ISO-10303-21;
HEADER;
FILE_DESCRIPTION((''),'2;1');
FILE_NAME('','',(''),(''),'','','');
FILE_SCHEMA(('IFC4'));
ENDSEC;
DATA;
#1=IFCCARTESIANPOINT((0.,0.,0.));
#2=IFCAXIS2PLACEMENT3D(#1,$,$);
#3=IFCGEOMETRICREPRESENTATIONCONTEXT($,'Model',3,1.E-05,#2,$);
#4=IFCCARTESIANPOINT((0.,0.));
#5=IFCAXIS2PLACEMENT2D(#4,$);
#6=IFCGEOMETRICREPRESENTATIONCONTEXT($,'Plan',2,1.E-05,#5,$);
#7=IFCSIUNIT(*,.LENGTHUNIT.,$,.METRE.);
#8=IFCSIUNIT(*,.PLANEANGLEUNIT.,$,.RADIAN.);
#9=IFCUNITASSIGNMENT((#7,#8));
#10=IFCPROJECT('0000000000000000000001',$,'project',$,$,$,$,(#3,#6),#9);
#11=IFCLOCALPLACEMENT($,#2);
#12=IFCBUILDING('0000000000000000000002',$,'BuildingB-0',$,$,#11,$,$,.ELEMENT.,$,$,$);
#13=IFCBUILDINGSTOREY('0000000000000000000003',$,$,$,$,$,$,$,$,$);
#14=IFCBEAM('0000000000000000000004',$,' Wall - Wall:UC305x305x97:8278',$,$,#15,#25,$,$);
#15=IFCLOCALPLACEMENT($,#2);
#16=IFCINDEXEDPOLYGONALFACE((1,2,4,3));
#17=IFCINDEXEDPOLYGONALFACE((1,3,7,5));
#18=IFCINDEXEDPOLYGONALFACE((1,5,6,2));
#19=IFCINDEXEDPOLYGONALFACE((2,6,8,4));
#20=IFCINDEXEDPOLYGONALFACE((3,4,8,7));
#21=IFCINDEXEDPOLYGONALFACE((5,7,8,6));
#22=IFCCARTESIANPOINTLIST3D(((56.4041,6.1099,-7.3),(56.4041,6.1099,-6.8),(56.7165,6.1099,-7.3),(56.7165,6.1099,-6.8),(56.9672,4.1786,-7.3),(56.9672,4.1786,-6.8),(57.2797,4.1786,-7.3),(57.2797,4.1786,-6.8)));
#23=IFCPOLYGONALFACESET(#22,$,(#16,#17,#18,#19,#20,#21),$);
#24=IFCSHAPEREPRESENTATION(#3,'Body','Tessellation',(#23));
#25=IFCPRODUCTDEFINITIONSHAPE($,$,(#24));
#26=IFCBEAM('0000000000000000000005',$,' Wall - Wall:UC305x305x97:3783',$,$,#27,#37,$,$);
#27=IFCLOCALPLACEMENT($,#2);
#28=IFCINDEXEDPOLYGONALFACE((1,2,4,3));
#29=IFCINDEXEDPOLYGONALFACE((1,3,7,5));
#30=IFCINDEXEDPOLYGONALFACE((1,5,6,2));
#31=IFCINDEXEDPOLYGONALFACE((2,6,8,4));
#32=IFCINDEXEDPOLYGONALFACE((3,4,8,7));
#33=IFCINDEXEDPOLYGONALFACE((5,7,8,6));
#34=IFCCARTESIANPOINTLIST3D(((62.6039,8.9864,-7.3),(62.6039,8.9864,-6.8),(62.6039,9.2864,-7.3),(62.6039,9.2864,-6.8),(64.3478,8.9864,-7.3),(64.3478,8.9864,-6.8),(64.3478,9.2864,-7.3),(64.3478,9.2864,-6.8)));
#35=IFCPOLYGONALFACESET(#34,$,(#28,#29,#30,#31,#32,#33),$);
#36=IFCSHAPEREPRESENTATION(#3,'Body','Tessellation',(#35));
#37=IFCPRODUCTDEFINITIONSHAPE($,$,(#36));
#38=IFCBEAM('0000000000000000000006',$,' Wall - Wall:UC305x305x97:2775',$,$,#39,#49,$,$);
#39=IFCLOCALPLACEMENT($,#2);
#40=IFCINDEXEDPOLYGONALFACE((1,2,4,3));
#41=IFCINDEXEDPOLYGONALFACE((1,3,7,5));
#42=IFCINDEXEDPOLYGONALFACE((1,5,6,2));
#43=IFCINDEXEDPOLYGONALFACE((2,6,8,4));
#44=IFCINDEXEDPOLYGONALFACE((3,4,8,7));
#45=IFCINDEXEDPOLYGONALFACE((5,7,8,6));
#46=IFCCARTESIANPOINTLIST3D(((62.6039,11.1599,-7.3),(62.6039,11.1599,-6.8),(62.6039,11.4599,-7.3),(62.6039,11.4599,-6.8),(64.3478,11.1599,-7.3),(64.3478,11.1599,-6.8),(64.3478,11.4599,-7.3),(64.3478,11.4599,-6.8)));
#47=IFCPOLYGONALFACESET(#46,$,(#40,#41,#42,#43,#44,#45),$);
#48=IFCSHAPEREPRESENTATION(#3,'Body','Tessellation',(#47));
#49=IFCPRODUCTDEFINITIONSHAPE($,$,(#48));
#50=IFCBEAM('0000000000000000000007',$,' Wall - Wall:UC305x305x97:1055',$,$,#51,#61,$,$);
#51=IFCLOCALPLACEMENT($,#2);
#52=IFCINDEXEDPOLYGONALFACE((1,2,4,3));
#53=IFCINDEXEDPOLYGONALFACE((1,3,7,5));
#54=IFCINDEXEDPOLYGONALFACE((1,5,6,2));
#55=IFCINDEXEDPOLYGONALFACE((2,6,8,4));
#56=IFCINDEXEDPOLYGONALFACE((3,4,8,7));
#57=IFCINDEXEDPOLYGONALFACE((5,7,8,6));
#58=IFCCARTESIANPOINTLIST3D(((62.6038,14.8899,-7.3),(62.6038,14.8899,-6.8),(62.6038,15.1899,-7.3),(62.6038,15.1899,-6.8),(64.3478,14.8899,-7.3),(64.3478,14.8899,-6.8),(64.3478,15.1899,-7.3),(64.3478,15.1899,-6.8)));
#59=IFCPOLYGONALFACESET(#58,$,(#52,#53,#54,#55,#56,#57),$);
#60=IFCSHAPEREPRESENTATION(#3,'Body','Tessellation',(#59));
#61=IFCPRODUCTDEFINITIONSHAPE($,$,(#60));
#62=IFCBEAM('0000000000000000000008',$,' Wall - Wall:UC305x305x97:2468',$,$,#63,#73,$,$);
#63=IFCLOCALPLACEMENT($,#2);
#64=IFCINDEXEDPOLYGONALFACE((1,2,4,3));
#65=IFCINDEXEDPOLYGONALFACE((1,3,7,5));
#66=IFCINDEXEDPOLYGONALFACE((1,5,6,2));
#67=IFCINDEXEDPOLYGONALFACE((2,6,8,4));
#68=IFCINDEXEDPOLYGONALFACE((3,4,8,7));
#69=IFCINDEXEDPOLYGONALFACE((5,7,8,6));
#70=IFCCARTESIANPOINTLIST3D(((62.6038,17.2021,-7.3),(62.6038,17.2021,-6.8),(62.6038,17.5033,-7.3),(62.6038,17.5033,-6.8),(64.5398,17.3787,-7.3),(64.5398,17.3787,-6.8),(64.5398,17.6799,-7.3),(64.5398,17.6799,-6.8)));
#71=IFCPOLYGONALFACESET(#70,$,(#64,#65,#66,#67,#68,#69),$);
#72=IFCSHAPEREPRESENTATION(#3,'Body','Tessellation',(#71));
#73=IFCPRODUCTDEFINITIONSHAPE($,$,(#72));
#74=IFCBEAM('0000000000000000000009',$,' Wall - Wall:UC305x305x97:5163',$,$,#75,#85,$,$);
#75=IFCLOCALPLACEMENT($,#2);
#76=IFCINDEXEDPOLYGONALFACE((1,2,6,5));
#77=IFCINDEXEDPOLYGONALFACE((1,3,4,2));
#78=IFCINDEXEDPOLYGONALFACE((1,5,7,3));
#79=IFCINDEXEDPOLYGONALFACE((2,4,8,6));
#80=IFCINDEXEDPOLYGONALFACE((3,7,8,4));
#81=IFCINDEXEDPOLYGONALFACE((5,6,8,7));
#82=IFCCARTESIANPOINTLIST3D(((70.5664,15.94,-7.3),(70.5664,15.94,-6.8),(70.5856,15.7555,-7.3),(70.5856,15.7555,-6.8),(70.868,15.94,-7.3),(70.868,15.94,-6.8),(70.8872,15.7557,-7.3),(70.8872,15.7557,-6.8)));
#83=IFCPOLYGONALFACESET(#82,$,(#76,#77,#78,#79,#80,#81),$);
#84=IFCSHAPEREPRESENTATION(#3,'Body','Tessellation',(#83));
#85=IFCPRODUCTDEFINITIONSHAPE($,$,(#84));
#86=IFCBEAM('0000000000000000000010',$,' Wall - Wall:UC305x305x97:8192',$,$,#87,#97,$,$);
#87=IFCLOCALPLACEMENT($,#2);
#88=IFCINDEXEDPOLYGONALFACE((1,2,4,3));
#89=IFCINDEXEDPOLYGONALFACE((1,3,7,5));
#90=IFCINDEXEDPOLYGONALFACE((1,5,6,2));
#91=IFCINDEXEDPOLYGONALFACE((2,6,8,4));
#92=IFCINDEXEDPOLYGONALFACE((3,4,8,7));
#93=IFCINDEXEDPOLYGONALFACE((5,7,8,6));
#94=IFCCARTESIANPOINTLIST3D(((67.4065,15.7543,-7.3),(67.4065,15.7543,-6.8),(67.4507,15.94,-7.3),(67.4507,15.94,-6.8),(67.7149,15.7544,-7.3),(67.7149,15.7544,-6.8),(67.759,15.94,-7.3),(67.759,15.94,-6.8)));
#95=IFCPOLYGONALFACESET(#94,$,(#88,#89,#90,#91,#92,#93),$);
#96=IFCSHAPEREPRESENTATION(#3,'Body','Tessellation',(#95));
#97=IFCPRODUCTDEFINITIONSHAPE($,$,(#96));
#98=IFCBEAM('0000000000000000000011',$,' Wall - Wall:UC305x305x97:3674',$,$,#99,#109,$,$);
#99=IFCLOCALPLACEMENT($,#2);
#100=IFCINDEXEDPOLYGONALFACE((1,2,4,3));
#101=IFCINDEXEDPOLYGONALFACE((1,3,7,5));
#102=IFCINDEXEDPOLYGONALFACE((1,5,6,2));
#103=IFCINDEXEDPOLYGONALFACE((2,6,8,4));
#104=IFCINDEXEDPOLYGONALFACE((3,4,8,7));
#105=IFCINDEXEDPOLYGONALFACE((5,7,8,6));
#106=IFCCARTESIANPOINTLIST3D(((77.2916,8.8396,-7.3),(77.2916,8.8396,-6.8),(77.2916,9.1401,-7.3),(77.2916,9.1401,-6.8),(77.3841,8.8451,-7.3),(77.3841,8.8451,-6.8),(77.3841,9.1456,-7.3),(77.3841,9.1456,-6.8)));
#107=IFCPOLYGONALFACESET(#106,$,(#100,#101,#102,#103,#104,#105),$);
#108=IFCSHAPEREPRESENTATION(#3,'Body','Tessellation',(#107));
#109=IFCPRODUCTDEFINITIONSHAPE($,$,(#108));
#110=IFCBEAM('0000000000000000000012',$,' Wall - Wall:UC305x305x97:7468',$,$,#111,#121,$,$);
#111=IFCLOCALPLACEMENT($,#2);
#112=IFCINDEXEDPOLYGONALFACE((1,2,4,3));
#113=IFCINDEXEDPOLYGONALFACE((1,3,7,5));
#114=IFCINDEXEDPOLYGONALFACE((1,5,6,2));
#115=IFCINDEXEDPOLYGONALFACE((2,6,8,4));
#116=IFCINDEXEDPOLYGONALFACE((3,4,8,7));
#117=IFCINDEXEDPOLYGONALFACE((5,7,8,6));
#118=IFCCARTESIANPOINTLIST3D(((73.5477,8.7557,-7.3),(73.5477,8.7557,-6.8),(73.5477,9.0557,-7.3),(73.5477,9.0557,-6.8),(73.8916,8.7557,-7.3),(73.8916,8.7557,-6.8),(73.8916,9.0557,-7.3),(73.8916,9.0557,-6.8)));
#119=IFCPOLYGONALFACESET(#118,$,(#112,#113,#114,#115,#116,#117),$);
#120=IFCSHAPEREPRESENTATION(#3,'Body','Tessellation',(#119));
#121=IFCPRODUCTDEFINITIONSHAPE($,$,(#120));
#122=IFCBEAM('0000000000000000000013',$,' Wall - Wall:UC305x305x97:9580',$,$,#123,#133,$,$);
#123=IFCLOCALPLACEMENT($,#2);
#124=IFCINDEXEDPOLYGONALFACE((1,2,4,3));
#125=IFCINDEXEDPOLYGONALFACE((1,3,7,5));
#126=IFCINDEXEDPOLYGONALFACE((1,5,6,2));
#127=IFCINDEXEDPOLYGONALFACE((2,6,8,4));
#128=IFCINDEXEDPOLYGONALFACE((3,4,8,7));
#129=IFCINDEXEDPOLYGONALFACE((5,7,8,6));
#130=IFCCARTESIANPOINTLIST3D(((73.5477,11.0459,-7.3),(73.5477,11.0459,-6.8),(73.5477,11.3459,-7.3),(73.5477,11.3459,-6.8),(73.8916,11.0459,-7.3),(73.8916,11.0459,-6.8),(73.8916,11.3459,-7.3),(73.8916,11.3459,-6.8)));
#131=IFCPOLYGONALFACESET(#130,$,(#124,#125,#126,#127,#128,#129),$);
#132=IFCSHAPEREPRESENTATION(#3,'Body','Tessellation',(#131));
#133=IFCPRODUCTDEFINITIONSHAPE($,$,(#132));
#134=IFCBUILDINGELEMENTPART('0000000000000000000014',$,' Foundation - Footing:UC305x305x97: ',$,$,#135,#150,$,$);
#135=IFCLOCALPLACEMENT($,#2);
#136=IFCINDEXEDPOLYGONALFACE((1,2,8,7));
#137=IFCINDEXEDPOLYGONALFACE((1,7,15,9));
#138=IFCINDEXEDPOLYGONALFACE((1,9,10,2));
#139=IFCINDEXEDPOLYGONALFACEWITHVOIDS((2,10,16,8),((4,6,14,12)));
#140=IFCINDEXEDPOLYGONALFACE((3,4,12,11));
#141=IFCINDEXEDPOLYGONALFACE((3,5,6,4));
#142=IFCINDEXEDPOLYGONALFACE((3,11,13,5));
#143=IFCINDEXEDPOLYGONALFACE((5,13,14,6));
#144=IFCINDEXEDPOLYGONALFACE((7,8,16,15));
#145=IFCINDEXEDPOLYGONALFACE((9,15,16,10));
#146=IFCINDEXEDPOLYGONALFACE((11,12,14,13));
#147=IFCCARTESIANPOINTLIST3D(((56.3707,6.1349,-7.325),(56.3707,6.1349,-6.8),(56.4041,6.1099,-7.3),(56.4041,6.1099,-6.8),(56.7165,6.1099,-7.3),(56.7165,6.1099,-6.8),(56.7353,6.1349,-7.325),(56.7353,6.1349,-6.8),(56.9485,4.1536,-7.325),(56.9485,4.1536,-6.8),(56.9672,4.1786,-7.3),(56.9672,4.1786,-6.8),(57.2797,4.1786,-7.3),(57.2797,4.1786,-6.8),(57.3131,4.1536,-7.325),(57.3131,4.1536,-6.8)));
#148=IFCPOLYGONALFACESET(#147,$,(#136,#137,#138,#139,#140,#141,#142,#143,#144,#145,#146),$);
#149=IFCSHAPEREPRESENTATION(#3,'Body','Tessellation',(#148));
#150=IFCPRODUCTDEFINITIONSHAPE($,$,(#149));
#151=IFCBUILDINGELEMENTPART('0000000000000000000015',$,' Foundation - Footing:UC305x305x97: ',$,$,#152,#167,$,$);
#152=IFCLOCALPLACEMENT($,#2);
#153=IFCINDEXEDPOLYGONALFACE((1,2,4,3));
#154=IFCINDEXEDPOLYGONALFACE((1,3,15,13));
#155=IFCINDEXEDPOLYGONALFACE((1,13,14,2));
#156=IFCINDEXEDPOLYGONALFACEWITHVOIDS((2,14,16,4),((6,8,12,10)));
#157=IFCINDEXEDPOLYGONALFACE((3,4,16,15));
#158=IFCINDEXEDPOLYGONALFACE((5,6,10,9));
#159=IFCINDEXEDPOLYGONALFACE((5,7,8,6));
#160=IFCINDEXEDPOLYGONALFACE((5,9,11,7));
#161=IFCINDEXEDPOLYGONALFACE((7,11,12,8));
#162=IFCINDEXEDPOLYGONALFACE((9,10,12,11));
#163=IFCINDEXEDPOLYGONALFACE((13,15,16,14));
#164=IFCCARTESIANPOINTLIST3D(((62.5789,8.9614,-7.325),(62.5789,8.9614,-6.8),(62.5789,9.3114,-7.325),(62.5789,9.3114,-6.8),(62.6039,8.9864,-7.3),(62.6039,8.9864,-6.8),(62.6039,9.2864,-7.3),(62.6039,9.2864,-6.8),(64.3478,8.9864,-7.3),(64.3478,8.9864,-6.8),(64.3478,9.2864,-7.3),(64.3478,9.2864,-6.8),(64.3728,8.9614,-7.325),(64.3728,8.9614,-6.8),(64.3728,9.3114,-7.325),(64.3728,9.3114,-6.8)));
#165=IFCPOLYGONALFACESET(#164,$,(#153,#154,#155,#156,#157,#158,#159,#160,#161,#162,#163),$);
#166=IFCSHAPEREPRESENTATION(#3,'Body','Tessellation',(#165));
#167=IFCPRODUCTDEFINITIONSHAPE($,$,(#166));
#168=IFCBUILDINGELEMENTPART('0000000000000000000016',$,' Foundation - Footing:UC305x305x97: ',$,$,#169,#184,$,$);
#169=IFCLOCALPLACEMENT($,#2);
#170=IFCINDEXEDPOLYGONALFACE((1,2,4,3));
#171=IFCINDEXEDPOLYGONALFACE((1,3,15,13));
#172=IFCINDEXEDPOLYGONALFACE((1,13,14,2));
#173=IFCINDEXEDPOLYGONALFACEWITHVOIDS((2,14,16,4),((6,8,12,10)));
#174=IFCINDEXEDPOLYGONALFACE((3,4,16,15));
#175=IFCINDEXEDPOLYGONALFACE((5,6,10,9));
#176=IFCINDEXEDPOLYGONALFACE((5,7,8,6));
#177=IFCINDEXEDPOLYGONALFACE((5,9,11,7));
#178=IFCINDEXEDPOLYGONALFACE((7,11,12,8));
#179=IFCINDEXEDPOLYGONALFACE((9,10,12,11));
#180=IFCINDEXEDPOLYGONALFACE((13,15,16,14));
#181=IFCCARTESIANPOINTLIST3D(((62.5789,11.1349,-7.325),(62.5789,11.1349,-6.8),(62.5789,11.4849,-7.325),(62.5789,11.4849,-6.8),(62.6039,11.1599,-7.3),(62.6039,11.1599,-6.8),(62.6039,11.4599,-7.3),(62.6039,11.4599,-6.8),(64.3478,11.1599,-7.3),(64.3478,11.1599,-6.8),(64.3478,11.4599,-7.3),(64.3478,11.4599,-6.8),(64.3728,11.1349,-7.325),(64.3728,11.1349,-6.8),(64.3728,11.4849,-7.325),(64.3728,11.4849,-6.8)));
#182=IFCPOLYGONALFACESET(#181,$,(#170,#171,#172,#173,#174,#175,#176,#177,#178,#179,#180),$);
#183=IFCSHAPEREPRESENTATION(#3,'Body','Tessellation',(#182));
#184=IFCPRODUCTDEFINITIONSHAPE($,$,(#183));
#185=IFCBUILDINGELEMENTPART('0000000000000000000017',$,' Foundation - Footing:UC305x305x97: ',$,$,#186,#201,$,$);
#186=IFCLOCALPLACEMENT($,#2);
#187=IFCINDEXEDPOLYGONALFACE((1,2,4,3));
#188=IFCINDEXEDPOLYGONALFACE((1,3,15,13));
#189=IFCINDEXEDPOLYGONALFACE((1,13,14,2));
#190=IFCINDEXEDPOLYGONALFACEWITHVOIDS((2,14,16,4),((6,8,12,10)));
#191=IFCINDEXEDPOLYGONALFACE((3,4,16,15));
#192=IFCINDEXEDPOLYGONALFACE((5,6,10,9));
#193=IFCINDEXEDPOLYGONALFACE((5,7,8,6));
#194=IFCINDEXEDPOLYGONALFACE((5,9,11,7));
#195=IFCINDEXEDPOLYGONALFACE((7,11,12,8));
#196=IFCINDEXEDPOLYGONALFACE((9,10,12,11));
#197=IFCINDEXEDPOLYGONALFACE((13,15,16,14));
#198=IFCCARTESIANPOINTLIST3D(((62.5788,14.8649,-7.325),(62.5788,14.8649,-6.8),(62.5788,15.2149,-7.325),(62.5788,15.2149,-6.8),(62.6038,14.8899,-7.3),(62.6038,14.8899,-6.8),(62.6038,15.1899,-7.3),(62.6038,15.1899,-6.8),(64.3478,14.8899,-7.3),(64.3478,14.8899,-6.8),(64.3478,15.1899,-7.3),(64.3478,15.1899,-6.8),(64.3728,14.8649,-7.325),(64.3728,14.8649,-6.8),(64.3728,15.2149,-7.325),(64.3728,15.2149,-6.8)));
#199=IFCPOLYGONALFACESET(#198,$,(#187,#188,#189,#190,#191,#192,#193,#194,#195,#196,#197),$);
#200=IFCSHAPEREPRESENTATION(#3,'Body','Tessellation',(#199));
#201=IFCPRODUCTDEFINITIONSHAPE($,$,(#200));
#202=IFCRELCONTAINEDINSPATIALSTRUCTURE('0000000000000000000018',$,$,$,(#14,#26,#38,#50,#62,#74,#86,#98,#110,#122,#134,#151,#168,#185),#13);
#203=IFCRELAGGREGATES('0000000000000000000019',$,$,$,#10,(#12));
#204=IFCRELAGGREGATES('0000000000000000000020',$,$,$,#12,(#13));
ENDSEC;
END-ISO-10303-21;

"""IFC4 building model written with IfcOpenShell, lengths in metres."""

from ifc_helpers import new_model, si_unit, origin, origin_2d, place, context, project, spatial, polyline, outline, extrude, element, save


model = new_model("IFC4")

# Units and contexts
model_context = context("Model", 3, precision=1e-05, world=origin())
plan_context = context("Plan", 2, precision=1e-05, world=origin_2d())
ifc_project = project(units=[si_unit("LENGTHUNIT", "METRE"), si_unit("PLANEANGLEUNIT", "RADIAN")], contexts=[model_context, plan_context])

# Building, storey
building_placement = place(None, origin())
building = spatial("IfcBuilding", under=ifc_project, at=building_placement, Name="BuildingB-0", CompositionType="ELEMENT")
storey = spatial("IfcBuildingStorey", under=building)

# Beams
element("IfcBeam", 1, inside=storey, Name=" Wall - Wall:UC305x305x97:8278", context=model_context, shape_type="SweptSolid", body=[
    extrude(outline(polyline([(56.9672, 4.1786, -7.3), (57.2797, 4.1786, -7.3), (56.7165, 6.1099, -7.3), (56.4041, 6.1099, -7.3), (56.9672, 4.1786, -7.3)])), None, (0.0, 0.0, 1.0), 0.5),
])
element("IfcBeam", 2, inside=storey, Name=" Wall - Wall:UC305x305x97:3783", context=model_context, shape_type="SweptSolid", body=[
    extrude(outline(polyline([(64.3478, 8.9864, -7.3), (62.6039, 8.9864, -7.3), (62.6039, 9.2864, -7.3), (64.3478, 9.2864, -7.3), (64.3478, 8.9864, -7.3)])), None, (0.0, 0.0, 1.0), 0.5),
])
element("IfcBeam", 3, inside=storey, Name=" Wall - Wall:UC305x305x97:2775", context=model_context, shape_type="SweptSolid", body=[
    extrude(outline(polyline([(64.3478, 11.1599, -7.3), (64.3478, 11.4599, -7.3), (62.6039, 11.4599, -7.3), (62.6039, 11.1599, -7.3), (64.3478, 11.1599, -7.3)])), None, (0.0, 0.0, 1.0), 0.5),
])
element("IfcBeam", 4, inside=storey, Name=" Wall - Wall:UC305x305x97:1055", context=model_context, shape_type="SweptSolid", body=[
    extrude(outline(polyline([(64.3478, 14.8899, -7.3), (64.3478, 15.1899, -7.3), (62.6038, 15.1899, -7.3), (62.6038, 14.8899, -7.3), (64.3478, 14.8899, -7.3)])), None, (0.0, 0.0, 1.0), 0.5),
])
element("IfcBeam", 5, inside=storey, Name=" Wall - Wall:UC305x305x97:2468", context=model_context, shape_type="SweptSolid", body=[
    extrude(outline(polyline([(64.5398, 17.3787, -7.3), (64.5398, 17.6799, -7.3), (62.6038, 17.5033, -7.3), (62.6038, 17.2021, -7.3), (64.5398, 17.3787, -7.3)])), None, (0.0, 0.0, 1.0), 0.5),
])
element("IfcBeam", 6, inside=storey, Name=" Wall - Wall:UC305x305x97:5163", context=model_context, shape_type="SweptSolid", body=[
    extrude(outline(polyline([(70.8872, 15.7557, -7.3), (70.868, 15.94, -7.3), (70.5664, 15.94, -7.3), (70.5856, 15.7555, -7.3), (70.8872, 15.7557, -7.3)])), None, (0.0, 0.0, 1.0), 0.5),
])
element("IfcBeam", 7, inside=storey, Name=" Wall - Wall:UC305x305x97:8192", context=model_context, shape_type="SweptSolid", body=[
    extrude(outline(polyline([(67.7149, 15.7544, -7.3), (67.759, 15.94, -7.3), (67.4507, 15.94, -7.3), (67.4065, 15.7543, -7.3), (67.7149, 15.7544, -7.3)])), None, (0.0, 0.0, 1.0), 0.5),
])
element("IfcBeam", 8, inside=storey, Name=" Wall - Wall:UC305x305x97:3674", context=model_context, shape_type="SweptSolid", body=[
    extrude(outline(polyline([(77.3841, 8.8451, -7.3), (77.2916, 8.8396, -7.3), (77.2916, 9.1401, -7.3), (77.3841, 9.1456, -7.3), (77.3841, 8.8451, -7.3)])), None, (0.0, 0.0, 1.0), 0.5),
])
element("IfcBeam", 9, inside=storey, Name=" Wall - Wall:UC305x305x97:7468", context=model_context, shape_type="SweptSolid", body=[
    extrude(outline(polyline([(73.8916, 8.7557, -7.3), (73.5477, 8.7557, -7.3), (73.5477, 9.0557, -7.3), (73.8916, 9.0557, -7.3), (73.8916, 8.7557, -7.3)])), None, (0.0, 0.0, 1.0), 0.5),
])
element("IfcBeam", 10, inside=storey, Name=" Wall - Wall:UC305x305x97:9580", context=model_context, shape_type="SweptSolid", body=[
    extrude(outline(polyline([(73.8916, 11.0459, -7.3), (73.5477, 11.0459, -7.3), (73.5477, 11.3459, -7.3), (73.8916, 11.3459, -7.3), (73.8916, 11.0459, -7.3)])), None, (0.0, 0.0, 1.0), 0.5),
])

# Building element parts, openings
building_element_part_1 = element("IfcBuildingElementPart", 11, inside=storey, Name=" Foundation - Footing:UC305x305x97: ", context=model_context, shape_type="SweptSolid", body=[
    extrude(outline(polyline([(56.9485, 4.1536, -7.325), (57.3131, 4.1536, -7.325), (56.7353, 6.1349, -7.325), (56.3707, 6.1349, -7.325), (56.9485, 4.1536, -7.325)])), None, (0.0, 0.0, 1.0), 0.525),
])
element("IfcOpeningElement", 12, inside=storey, cuts=building_element_part_1, context=model_context, shape_type="SweptSolid", body=[
    extrude(outline(polyline([(56.9672, 4.1786, -7.3), (57.2797, 4.1786, -7.3), (56.7165, 6.1099, -7.3), (56.4041, 6.1099, -7.3), (56.9672, 4.1786, -7.3)])), None, (0.0, 0.0, 1.0), 0.5),
])
building_element_part_2 = element("IfcBuildingElementPart", 13, inside=storey, Name=" Foundation - Footing:UC305x305x97: ", context=model_context, shape_type="SweptSolid", body=[
    extrude(outline(polyline([(64.3728, 8.9614, -7.325), (62.5789, 8.9614, -7.325), (62.5789, 9.3114, -7.325), (64.3728, 9.3114, -7.325), (64.3728, 8.9614, -7.325)])), None, (0.0, 0.0, 1.0), 0.525),
])
element("IfcOpeningElement", 14, inside=storey, cuts=building_element_part_2, context=model_context, shape_type="SweptSolid", body=[
    extrude(outline(polyline([(64.3478, 8.9864, -7.3), (62.6039, 8.9864, -7.3), (62.6039, 9.2864, -7.3), (64.3478, 9.2864, -7.3), (64.3478, 8.9864, -7.3)])), None, (0.0, 0.0, 1.0), 0.5),
])
building_element_part_3 = element("IfcBuildingElementPart", 15, inside=storey, Name=" Foundation - Footing:UC305x305x97: ", context=model_context, shape_type="SweptSolid", body=[
    extrude(outline(polyline([(64.3728, 11.1349, -7.325), (64.3728, 11.4849, -7.325), (62.5789, 11.4849, -7.325), (62.5789, 11.1349, -7.325), (64.3728, 11.1349, -7.325)])), None, (0.0, 0.0, 1.0), 0.525),
])
element("IfcOpeningElement", 16, inside=storey, cuts=building_element_part_3, context=model_context, shape_type="SweptSolid", body=[
    extrude(outline(polyline([(64.3478, 11.1599, -7.3), (64.3478, 11.4599, -7.3), (62.6039, 11.4599, -7.3), (62.6039, 11.1599, -7.3), (64.3478, 11.1599, -7.3)])), None, (0.0, 0.0, 1.0), 0.5),
])
building_element_part_4 = element("IfcBuildingElementPart", 17, inside=storey, Name=" Foundation - Footing:UC305x305x97: ", context=model_context, shape_type="SweptSolid", body=[
    extrude(outline(polyline([(64.3728, 14.8649, -7.325), (64.3728, 15.2149, -7.325), (62.5788, 15.2149, -7.325), (62.5788, 14.8649, -7.325), (64.3728, 14.8649, -7.325)])), None, (0.0, 0.0, 1.0), 0.525),
])
element("IfcOpeningElement", 18, inside=storey, cuts=building_element_part_4, context=model_context, shape_type="SweptSolid", body=[
    extrude(outline(polyline([(64.3478, 14.8899, -7.3), (64.3478, 15.1899, -7.3), (62.6038, 15.1899, -7.3), (62.6038, 14.8899, -7.3), (64.3478, 14.8899, -7.3)])), None, (0.0, 0.0, 1.0), 0.5),
])

save(model, "model.ifc")
